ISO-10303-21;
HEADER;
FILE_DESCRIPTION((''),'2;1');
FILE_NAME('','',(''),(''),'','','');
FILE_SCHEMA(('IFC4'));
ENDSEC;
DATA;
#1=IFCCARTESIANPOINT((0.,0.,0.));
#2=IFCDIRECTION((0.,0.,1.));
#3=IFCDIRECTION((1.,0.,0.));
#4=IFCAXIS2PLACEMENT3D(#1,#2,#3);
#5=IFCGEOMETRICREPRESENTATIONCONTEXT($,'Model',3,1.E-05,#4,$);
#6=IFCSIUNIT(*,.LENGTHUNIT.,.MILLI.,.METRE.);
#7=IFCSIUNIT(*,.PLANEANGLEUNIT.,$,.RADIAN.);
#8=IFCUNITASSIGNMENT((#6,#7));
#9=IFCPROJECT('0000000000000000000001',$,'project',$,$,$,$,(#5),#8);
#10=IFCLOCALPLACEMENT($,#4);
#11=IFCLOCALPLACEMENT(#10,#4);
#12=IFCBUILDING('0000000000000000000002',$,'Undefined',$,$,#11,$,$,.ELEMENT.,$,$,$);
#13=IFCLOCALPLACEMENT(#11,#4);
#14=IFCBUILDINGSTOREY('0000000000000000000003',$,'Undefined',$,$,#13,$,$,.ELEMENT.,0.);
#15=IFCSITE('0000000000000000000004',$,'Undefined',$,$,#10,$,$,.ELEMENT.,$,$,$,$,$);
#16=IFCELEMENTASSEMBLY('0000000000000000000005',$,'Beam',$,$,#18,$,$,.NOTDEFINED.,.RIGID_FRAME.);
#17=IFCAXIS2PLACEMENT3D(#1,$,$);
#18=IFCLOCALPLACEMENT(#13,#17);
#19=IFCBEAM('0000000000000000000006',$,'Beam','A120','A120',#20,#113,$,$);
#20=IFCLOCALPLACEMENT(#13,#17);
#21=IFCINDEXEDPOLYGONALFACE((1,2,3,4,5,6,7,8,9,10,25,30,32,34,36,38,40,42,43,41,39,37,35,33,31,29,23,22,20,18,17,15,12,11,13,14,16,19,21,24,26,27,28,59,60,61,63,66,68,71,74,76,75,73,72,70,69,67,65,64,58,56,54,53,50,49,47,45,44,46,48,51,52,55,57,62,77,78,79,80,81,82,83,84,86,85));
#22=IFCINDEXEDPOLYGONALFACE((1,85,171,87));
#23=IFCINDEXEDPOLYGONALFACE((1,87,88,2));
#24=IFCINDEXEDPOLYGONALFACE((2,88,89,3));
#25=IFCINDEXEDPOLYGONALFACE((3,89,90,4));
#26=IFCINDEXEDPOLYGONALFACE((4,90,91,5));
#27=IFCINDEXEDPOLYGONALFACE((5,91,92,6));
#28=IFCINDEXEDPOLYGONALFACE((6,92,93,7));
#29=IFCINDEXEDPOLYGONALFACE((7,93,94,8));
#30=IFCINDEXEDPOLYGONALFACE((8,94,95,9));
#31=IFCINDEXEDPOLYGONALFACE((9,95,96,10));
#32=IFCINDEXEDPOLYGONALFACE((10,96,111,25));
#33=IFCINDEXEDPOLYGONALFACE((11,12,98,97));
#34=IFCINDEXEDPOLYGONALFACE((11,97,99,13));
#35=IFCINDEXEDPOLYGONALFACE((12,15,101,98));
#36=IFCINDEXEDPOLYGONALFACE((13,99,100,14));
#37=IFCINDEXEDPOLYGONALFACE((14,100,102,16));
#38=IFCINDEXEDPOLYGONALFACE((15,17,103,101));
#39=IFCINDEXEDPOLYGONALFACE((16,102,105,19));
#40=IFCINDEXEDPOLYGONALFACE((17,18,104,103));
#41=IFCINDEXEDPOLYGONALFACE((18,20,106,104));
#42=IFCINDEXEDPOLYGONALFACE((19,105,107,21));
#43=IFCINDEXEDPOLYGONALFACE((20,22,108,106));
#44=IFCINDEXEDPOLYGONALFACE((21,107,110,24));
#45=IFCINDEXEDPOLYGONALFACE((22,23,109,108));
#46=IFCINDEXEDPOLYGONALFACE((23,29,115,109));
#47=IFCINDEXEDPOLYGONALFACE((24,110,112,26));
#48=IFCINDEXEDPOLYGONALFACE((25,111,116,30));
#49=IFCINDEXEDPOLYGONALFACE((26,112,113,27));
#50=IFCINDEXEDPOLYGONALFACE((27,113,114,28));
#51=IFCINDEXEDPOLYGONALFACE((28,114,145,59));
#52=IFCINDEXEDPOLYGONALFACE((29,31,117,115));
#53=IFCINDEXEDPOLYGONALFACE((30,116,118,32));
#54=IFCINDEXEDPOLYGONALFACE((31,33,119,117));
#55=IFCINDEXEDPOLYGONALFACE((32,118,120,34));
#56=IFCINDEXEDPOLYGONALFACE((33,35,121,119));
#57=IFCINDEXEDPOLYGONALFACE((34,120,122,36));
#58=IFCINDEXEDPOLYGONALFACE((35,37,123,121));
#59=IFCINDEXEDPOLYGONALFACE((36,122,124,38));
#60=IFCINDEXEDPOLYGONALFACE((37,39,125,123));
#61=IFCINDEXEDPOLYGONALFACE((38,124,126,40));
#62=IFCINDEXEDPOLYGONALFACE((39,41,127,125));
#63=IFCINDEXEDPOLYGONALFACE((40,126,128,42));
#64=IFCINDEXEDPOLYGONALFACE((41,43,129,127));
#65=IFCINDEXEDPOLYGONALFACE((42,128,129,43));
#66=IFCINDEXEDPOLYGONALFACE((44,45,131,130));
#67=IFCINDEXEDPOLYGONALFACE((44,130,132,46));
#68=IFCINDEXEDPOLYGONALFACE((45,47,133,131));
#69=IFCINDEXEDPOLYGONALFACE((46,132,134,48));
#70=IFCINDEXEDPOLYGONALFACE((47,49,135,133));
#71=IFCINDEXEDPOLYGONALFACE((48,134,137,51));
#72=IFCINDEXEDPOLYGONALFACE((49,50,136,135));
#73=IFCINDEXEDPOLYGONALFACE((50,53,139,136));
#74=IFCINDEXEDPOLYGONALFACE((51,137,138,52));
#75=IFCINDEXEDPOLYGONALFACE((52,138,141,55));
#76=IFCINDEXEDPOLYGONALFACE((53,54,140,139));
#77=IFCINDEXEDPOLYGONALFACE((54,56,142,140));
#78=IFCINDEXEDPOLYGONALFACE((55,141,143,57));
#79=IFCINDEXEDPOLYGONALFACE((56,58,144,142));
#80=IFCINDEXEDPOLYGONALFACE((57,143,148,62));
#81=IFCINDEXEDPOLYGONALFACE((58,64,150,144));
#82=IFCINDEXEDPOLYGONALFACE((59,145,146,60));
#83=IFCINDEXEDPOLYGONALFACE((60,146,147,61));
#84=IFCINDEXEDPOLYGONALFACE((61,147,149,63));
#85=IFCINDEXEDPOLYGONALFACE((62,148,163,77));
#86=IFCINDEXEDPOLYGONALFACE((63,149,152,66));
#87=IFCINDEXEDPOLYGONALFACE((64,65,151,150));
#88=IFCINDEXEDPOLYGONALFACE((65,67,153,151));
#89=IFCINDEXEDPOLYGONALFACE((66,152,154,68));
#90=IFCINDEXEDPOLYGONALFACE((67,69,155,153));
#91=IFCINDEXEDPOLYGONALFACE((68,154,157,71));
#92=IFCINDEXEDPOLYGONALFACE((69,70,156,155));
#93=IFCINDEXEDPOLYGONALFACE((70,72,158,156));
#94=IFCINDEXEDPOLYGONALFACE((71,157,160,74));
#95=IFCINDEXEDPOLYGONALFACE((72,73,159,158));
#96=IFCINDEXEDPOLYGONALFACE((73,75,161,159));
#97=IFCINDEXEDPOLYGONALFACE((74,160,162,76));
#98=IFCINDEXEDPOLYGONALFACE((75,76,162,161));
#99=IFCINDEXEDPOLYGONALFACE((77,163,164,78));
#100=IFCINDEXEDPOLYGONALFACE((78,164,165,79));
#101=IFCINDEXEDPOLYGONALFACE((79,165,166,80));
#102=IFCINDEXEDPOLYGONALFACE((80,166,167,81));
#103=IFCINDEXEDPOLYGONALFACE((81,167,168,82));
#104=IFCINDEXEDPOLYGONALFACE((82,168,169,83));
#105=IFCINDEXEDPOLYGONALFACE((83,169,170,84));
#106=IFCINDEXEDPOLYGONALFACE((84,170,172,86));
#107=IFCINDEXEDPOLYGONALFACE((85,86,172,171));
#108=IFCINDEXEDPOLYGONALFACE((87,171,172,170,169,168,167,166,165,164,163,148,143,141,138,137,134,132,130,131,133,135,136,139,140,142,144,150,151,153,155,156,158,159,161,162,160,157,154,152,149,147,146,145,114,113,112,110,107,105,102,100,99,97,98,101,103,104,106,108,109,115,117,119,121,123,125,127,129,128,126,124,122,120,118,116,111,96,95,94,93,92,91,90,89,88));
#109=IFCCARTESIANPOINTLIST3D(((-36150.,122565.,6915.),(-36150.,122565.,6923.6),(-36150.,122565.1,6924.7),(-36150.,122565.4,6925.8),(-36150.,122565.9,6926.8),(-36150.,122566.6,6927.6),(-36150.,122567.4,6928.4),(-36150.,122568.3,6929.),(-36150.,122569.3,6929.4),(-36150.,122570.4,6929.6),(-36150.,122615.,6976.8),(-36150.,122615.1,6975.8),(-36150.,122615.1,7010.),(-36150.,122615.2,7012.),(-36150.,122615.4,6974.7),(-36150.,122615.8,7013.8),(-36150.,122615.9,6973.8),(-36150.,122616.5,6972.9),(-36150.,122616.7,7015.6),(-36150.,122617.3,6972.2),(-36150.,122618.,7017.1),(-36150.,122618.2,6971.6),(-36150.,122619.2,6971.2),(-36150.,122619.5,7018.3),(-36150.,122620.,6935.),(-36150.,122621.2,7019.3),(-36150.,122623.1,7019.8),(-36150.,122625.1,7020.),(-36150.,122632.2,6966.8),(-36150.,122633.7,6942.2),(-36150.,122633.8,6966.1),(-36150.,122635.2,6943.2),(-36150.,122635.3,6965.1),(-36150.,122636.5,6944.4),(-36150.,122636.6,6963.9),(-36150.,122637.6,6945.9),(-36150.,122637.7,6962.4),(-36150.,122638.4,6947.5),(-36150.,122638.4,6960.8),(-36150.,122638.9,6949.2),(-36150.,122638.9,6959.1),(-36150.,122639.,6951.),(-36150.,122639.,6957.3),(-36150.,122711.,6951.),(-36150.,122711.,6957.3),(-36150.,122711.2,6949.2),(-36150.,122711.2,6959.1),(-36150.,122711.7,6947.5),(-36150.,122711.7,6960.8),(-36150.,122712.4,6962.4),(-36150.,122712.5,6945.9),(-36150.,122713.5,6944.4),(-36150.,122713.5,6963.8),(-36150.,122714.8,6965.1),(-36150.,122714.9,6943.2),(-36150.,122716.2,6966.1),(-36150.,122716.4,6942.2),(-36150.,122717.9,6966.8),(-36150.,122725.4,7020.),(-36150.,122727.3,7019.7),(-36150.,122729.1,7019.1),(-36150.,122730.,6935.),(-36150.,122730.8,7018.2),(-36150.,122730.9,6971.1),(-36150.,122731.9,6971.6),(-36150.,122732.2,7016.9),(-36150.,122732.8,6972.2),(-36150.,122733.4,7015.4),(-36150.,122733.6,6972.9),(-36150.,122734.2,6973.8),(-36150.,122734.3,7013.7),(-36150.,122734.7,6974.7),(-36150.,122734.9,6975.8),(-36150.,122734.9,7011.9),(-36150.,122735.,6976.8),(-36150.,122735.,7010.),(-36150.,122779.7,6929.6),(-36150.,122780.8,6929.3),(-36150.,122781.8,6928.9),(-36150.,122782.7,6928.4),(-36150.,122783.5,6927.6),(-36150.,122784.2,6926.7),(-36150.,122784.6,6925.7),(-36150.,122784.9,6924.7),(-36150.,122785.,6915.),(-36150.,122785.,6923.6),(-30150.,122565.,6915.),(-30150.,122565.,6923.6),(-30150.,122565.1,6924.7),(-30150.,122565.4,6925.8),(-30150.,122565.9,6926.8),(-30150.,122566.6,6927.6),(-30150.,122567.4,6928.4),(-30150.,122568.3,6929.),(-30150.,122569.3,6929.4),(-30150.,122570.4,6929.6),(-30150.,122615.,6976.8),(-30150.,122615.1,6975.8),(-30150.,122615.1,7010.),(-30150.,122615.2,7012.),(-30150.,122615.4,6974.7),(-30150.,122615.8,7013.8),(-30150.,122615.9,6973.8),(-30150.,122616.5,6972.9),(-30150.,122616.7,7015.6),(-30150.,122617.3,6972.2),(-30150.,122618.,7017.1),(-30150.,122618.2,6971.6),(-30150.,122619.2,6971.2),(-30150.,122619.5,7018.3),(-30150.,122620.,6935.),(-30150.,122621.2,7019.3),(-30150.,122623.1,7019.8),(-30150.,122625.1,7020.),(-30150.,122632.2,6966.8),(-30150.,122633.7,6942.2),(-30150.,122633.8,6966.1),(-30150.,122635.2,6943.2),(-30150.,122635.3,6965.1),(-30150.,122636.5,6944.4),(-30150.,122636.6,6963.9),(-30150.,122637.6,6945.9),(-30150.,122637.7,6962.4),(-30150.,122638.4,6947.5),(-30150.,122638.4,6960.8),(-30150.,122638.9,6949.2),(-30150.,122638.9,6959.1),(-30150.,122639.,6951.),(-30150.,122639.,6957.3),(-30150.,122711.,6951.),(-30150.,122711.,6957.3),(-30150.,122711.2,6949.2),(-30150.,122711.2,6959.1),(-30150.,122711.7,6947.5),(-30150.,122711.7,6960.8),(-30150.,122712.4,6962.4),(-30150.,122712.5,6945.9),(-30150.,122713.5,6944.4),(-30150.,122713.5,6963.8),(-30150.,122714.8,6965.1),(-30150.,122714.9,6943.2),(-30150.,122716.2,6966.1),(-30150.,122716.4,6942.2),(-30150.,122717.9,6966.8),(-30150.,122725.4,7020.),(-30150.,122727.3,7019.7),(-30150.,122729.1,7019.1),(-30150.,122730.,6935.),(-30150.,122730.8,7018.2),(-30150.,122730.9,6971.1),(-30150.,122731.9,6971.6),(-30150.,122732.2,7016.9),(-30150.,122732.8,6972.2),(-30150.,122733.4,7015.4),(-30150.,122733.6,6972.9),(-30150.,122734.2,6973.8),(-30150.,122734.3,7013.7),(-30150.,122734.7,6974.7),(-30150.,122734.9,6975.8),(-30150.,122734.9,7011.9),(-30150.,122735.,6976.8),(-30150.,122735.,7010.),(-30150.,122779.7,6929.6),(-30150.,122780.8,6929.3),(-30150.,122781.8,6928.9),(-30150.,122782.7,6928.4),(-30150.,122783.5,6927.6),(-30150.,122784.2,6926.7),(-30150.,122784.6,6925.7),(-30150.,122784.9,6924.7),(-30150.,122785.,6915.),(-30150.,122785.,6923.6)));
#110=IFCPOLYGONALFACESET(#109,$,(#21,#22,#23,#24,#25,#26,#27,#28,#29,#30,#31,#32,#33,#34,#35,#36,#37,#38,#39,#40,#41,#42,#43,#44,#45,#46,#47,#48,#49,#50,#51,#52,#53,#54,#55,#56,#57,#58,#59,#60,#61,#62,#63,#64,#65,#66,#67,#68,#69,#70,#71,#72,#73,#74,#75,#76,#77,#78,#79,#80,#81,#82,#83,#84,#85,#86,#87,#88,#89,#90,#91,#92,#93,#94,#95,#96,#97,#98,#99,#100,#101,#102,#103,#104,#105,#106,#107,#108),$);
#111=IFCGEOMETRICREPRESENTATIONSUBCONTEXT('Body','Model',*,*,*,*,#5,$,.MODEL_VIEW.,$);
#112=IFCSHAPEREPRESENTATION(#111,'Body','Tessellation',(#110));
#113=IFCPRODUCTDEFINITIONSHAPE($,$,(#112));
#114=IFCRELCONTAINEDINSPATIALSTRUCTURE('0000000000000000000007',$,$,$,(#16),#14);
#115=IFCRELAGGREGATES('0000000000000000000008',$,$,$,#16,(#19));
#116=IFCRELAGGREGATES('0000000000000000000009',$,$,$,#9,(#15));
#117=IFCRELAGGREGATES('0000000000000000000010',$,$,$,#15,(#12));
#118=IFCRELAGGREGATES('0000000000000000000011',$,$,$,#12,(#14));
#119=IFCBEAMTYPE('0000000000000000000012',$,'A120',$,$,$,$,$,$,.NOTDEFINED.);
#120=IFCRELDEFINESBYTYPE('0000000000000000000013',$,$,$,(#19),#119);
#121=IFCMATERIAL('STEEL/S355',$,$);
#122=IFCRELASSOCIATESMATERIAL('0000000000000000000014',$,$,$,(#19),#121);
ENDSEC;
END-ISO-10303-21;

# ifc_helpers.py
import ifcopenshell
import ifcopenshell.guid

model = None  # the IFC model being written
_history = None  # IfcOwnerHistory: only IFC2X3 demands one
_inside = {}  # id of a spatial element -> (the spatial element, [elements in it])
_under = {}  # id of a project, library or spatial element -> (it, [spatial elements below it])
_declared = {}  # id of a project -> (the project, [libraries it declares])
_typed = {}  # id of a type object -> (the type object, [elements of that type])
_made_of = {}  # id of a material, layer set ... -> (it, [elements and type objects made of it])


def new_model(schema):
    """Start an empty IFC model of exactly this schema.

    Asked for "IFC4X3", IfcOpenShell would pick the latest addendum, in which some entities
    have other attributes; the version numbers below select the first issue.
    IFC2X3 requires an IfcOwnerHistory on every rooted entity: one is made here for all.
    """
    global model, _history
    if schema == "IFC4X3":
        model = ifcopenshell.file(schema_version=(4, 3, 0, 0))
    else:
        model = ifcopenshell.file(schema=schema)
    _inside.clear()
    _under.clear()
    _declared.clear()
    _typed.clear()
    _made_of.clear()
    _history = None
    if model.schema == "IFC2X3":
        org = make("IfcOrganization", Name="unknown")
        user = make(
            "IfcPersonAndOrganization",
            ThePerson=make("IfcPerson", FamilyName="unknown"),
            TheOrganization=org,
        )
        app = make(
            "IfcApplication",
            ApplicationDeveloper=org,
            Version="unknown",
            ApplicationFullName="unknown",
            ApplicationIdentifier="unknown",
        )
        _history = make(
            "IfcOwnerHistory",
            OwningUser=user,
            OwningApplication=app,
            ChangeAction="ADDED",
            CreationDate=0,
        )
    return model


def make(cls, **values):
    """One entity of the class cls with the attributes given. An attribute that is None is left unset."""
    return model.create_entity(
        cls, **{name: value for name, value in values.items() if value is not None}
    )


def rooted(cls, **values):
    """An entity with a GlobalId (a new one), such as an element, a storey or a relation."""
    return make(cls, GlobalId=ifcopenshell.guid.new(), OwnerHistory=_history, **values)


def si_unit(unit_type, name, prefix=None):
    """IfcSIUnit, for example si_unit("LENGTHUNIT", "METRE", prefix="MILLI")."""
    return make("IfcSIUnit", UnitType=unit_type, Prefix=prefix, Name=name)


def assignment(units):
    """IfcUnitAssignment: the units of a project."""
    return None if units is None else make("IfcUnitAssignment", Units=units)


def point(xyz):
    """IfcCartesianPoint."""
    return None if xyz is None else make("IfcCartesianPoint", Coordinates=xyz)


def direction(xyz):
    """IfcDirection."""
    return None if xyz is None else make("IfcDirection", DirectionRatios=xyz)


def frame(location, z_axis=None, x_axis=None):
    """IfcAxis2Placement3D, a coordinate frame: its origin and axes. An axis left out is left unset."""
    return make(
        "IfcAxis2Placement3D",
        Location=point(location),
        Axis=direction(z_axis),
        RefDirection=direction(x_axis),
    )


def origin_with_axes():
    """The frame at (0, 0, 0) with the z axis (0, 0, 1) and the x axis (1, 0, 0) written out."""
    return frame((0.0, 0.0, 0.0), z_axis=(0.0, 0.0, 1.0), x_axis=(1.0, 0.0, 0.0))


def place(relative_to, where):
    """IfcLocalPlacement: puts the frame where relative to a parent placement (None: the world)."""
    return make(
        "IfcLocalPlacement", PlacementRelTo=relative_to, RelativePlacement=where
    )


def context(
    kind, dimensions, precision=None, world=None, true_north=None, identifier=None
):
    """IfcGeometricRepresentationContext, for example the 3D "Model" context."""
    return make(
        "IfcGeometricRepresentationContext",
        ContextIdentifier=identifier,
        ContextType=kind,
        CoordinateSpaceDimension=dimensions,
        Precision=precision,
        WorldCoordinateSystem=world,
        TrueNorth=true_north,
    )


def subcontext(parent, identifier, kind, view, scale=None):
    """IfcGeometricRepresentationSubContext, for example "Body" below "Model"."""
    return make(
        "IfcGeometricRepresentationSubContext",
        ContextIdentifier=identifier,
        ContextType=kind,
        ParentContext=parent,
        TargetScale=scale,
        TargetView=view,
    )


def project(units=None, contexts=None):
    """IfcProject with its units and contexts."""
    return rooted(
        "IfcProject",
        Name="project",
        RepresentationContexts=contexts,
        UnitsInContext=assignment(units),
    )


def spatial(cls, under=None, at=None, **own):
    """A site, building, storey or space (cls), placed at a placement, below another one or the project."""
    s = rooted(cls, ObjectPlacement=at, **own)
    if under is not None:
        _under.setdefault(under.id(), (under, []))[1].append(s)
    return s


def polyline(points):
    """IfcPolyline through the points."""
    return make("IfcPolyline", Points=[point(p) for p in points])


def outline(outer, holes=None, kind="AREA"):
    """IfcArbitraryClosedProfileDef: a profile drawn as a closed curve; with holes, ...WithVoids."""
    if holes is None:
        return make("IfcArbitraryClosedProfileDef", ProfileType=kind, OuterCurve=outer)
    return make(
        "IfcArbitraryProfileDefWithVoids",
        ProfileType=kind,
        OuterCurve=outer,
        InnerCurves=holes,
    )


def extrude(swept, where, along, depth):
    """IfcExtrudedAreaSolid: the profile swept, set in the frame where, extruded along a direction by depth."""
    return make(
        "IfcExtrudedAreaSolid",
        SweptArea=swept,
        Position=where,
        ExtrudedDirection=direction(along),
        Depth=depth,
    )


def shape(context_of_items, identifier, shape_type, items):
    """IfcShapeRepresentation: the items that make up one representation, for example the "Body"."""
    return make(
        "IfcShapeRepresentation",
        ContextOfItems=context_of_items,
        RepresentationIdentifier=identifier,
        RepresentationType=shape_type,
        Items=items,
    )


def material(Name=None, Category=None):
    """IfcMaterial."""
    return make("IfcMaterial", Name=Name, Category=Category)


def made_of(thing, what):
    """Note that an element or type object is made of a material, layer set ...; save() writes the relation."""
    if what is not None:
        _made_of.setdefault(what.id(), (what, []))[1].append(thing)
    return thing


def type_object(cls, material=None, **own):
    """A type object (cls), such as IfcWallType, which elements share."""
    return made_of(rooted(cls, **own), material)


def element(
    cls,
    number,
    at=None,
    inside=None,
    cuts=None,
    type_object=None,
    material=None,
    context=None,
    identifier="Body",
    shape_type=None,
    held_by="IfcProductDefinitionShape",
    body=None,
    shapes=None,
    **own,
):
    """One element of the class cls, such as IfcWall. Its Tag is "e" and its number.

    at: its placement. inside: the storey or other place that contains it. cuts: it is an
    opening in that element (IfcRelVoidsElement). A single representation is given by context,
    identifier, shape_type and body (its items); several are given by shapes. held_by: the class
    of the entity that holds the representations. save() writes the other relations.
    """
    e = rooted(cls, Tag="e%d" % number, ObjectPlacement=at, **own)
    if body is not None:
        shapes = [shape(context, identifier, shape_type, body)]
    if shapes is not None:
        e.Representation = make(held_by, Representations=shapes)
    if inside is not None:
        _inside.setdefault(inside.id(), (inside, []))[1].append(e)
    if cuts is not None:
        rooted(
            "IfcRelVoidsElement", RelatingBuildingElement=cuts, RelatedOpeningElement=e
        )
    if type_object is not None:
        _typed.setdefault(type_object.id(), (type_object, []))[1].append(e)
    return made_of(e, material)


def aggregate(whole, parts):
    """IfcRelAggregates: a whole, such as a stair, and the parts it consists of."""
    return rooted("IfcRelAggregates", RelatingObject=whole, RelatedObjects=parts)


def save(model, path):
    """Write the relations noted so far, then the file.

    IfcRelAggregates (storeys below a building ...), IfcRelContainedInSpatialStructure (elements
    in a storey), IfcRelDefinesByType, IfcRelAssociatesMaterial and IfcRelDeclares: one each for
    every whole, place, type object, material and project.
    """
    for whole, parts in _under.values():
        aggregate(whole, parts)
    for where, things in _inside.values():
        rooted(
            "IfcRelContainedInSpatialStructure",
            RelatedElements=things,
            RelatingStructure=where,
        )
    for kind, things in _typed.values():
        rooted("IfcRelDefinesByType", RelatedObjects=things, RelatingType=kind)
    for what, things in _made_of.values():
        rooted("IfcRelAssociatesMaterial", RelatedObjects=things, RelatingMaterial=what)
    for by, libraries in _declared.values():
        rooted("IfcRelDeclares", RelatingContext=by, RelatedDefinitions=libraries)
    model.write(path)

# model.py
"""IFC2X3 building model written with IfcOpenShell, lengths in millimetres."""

from ifc_helpers import new_model, si_unit, frame, origin_with_axes, place, context, subcontext, project, spatial, polyline, outline, extrude, material, type_object, element, aggregate, save


model = new_model("IFC2X3")

# Units and contexts
model_context = context("Model", 3, precision=1e-05, world=origin_with_axes())
body_context = subcontext(model_context, "Body", "Model", "MODEL_VIEW")
ifc_project = project(units=[si_unit("LENGTHUNIT", "METRE", prefix="MILLI"), si_unit("PLANEANGLEUNIT", "RADIAN")], contexts=[model_context])

# Site, building, storey
site_placement = place(None, origin_with_axes())
site = spatial("IfcSite", under=ifc_project, at=site_placement, Name="Undefined", CompositionType="ELEMENT")
building_placement = place(site_placement, origin_with_axes())
building = spatial("IfcBuilding", under=site, at=building_placement, Name="Undefined", CompositionType="ELEMENT")
storey_placement = place(building_placement, origin_with_axes())
storey = spatial("IfcBuildingStorey", under=building, at=storey_placement, Name="Undefined", CompositionType="ELEMENT", Elevation=0.0)

# Element assembly, beam
ifc_material_1 = material(Name="STEEL/S355")
beam_type_1 = type_object("IfcBeamType", Name="A120", PredefinedType="NOTDEFINED")
assembly_1_placement = place(storey_placement, origin_with_axes())
assembly_1 = element("IfcElementAssembly", 1, at=assembly_1_placement, inside=storey, Name="Beam", AssemblyPlace="NOTDEFINED", PredefinedType="RIGID_FRAME")
beam_1_placement = place(assembly_1_placement, frame((-36150.0, 122675.0, 6967.5), z_axis=(0.0, 0.000118, 1.0), x_axis=(1.0, 0.0, 0.0)))
beam_1 = element("IfcBeam", 2, at=beam_1_placement, type_object=beam_type_1, material=ifc_material_1, Name="Beam", Description="A120", ObjectType="A120", context=body_context, shape_type="SweptSolid", body=[
    extrude(outline(polyline([(-110.0, -52.5), (-110.0, -43.9), (-109.9, -42.8), (-109.6, -41.8), (-109.1, -40.8), (-108.5, -39.9), (-107.7, -39.1), (-106.7, -38.6), (-105.7, -38.2), (-104.7, -37.9), (-55.0, -32.5), (-41.3, -25.3), (-39.8, -24.3), (-38.5, -23.1), (-37.4, -21.6), (-36.6, -20.0), (-36.2, -18.3), (-36.0, -16.5), (-36.0, -10.2), (-36.1, -8.4), (-36.6, -6.7), (-37.4, -5.1), (-38.4, -3.7), (-39.7, -2.4), (-41.2, -1.4), (-42.8, -0.7), (-55.9, 3.6), (-56.9, 4.1), (-57.8, 4.7), (-58.5, 5.4), (-59.2, 6.3), (-59.6, 7.2), (-59.9, 8.3), (-60.0, 9.3), (-60.0, 42.5), (-59.8, 44.4), (-59.3, 46.2), (-58.4, 47.9), (-57.2, 49.4), (-55.7, 50.7), (-54.1, 51.6), (-52.3, 52.2), (-50.4, 52.5), (50.0, 52.5), (51.9, 52.3), (53.8, 51.7), (55.5, 50.8), (57.1, 49.6), (58.3, 48.1), (59.2, 46.3), (59.8, 44.4), (60.0, 42.5), (60.0, 9.3), (59.9, 8.3), (59.6, 7.2), (59.2, 6.3), (58.5, 5.4), (57.8, 4.7), (56.9, 4.1), (55.9, 3.6), (42.8, -0.7), (41.2, -1.4), (39.7, -2.4), (38.4, -3.7), (37.4, -5.1), (36.6, -6.7), (36.1, -8.4), (36.0, -10.2), (36.0, -16.5), (36.2, -18.3), (36.6, -20.0), (37.4, -21.6), (38.5, -23.1), (39.8, -24.3), (41.3, -25.3), (55.0, -32.5), (104.7, -37.9), (105.7, -38.2), (106.7, -38.6), (107.7, -39.1), (108.5, -39.9), (109.1, -40.8), (109.6, -41.8), (109.9, -42.8), (110.0, -43.9), (110.0, -52.5), (-110.0, -52.5)])), frame((6000.0, 0.0, 0.0), z_axis=(-1.0, 0.0, 0.0), x_axis=(0.0, -1.0, 0.0)), (0.0, 0.0, 1.0), 6000.0),
])
aggregate(assembly_1, [beam_1])

save(model, "model.ifc")
